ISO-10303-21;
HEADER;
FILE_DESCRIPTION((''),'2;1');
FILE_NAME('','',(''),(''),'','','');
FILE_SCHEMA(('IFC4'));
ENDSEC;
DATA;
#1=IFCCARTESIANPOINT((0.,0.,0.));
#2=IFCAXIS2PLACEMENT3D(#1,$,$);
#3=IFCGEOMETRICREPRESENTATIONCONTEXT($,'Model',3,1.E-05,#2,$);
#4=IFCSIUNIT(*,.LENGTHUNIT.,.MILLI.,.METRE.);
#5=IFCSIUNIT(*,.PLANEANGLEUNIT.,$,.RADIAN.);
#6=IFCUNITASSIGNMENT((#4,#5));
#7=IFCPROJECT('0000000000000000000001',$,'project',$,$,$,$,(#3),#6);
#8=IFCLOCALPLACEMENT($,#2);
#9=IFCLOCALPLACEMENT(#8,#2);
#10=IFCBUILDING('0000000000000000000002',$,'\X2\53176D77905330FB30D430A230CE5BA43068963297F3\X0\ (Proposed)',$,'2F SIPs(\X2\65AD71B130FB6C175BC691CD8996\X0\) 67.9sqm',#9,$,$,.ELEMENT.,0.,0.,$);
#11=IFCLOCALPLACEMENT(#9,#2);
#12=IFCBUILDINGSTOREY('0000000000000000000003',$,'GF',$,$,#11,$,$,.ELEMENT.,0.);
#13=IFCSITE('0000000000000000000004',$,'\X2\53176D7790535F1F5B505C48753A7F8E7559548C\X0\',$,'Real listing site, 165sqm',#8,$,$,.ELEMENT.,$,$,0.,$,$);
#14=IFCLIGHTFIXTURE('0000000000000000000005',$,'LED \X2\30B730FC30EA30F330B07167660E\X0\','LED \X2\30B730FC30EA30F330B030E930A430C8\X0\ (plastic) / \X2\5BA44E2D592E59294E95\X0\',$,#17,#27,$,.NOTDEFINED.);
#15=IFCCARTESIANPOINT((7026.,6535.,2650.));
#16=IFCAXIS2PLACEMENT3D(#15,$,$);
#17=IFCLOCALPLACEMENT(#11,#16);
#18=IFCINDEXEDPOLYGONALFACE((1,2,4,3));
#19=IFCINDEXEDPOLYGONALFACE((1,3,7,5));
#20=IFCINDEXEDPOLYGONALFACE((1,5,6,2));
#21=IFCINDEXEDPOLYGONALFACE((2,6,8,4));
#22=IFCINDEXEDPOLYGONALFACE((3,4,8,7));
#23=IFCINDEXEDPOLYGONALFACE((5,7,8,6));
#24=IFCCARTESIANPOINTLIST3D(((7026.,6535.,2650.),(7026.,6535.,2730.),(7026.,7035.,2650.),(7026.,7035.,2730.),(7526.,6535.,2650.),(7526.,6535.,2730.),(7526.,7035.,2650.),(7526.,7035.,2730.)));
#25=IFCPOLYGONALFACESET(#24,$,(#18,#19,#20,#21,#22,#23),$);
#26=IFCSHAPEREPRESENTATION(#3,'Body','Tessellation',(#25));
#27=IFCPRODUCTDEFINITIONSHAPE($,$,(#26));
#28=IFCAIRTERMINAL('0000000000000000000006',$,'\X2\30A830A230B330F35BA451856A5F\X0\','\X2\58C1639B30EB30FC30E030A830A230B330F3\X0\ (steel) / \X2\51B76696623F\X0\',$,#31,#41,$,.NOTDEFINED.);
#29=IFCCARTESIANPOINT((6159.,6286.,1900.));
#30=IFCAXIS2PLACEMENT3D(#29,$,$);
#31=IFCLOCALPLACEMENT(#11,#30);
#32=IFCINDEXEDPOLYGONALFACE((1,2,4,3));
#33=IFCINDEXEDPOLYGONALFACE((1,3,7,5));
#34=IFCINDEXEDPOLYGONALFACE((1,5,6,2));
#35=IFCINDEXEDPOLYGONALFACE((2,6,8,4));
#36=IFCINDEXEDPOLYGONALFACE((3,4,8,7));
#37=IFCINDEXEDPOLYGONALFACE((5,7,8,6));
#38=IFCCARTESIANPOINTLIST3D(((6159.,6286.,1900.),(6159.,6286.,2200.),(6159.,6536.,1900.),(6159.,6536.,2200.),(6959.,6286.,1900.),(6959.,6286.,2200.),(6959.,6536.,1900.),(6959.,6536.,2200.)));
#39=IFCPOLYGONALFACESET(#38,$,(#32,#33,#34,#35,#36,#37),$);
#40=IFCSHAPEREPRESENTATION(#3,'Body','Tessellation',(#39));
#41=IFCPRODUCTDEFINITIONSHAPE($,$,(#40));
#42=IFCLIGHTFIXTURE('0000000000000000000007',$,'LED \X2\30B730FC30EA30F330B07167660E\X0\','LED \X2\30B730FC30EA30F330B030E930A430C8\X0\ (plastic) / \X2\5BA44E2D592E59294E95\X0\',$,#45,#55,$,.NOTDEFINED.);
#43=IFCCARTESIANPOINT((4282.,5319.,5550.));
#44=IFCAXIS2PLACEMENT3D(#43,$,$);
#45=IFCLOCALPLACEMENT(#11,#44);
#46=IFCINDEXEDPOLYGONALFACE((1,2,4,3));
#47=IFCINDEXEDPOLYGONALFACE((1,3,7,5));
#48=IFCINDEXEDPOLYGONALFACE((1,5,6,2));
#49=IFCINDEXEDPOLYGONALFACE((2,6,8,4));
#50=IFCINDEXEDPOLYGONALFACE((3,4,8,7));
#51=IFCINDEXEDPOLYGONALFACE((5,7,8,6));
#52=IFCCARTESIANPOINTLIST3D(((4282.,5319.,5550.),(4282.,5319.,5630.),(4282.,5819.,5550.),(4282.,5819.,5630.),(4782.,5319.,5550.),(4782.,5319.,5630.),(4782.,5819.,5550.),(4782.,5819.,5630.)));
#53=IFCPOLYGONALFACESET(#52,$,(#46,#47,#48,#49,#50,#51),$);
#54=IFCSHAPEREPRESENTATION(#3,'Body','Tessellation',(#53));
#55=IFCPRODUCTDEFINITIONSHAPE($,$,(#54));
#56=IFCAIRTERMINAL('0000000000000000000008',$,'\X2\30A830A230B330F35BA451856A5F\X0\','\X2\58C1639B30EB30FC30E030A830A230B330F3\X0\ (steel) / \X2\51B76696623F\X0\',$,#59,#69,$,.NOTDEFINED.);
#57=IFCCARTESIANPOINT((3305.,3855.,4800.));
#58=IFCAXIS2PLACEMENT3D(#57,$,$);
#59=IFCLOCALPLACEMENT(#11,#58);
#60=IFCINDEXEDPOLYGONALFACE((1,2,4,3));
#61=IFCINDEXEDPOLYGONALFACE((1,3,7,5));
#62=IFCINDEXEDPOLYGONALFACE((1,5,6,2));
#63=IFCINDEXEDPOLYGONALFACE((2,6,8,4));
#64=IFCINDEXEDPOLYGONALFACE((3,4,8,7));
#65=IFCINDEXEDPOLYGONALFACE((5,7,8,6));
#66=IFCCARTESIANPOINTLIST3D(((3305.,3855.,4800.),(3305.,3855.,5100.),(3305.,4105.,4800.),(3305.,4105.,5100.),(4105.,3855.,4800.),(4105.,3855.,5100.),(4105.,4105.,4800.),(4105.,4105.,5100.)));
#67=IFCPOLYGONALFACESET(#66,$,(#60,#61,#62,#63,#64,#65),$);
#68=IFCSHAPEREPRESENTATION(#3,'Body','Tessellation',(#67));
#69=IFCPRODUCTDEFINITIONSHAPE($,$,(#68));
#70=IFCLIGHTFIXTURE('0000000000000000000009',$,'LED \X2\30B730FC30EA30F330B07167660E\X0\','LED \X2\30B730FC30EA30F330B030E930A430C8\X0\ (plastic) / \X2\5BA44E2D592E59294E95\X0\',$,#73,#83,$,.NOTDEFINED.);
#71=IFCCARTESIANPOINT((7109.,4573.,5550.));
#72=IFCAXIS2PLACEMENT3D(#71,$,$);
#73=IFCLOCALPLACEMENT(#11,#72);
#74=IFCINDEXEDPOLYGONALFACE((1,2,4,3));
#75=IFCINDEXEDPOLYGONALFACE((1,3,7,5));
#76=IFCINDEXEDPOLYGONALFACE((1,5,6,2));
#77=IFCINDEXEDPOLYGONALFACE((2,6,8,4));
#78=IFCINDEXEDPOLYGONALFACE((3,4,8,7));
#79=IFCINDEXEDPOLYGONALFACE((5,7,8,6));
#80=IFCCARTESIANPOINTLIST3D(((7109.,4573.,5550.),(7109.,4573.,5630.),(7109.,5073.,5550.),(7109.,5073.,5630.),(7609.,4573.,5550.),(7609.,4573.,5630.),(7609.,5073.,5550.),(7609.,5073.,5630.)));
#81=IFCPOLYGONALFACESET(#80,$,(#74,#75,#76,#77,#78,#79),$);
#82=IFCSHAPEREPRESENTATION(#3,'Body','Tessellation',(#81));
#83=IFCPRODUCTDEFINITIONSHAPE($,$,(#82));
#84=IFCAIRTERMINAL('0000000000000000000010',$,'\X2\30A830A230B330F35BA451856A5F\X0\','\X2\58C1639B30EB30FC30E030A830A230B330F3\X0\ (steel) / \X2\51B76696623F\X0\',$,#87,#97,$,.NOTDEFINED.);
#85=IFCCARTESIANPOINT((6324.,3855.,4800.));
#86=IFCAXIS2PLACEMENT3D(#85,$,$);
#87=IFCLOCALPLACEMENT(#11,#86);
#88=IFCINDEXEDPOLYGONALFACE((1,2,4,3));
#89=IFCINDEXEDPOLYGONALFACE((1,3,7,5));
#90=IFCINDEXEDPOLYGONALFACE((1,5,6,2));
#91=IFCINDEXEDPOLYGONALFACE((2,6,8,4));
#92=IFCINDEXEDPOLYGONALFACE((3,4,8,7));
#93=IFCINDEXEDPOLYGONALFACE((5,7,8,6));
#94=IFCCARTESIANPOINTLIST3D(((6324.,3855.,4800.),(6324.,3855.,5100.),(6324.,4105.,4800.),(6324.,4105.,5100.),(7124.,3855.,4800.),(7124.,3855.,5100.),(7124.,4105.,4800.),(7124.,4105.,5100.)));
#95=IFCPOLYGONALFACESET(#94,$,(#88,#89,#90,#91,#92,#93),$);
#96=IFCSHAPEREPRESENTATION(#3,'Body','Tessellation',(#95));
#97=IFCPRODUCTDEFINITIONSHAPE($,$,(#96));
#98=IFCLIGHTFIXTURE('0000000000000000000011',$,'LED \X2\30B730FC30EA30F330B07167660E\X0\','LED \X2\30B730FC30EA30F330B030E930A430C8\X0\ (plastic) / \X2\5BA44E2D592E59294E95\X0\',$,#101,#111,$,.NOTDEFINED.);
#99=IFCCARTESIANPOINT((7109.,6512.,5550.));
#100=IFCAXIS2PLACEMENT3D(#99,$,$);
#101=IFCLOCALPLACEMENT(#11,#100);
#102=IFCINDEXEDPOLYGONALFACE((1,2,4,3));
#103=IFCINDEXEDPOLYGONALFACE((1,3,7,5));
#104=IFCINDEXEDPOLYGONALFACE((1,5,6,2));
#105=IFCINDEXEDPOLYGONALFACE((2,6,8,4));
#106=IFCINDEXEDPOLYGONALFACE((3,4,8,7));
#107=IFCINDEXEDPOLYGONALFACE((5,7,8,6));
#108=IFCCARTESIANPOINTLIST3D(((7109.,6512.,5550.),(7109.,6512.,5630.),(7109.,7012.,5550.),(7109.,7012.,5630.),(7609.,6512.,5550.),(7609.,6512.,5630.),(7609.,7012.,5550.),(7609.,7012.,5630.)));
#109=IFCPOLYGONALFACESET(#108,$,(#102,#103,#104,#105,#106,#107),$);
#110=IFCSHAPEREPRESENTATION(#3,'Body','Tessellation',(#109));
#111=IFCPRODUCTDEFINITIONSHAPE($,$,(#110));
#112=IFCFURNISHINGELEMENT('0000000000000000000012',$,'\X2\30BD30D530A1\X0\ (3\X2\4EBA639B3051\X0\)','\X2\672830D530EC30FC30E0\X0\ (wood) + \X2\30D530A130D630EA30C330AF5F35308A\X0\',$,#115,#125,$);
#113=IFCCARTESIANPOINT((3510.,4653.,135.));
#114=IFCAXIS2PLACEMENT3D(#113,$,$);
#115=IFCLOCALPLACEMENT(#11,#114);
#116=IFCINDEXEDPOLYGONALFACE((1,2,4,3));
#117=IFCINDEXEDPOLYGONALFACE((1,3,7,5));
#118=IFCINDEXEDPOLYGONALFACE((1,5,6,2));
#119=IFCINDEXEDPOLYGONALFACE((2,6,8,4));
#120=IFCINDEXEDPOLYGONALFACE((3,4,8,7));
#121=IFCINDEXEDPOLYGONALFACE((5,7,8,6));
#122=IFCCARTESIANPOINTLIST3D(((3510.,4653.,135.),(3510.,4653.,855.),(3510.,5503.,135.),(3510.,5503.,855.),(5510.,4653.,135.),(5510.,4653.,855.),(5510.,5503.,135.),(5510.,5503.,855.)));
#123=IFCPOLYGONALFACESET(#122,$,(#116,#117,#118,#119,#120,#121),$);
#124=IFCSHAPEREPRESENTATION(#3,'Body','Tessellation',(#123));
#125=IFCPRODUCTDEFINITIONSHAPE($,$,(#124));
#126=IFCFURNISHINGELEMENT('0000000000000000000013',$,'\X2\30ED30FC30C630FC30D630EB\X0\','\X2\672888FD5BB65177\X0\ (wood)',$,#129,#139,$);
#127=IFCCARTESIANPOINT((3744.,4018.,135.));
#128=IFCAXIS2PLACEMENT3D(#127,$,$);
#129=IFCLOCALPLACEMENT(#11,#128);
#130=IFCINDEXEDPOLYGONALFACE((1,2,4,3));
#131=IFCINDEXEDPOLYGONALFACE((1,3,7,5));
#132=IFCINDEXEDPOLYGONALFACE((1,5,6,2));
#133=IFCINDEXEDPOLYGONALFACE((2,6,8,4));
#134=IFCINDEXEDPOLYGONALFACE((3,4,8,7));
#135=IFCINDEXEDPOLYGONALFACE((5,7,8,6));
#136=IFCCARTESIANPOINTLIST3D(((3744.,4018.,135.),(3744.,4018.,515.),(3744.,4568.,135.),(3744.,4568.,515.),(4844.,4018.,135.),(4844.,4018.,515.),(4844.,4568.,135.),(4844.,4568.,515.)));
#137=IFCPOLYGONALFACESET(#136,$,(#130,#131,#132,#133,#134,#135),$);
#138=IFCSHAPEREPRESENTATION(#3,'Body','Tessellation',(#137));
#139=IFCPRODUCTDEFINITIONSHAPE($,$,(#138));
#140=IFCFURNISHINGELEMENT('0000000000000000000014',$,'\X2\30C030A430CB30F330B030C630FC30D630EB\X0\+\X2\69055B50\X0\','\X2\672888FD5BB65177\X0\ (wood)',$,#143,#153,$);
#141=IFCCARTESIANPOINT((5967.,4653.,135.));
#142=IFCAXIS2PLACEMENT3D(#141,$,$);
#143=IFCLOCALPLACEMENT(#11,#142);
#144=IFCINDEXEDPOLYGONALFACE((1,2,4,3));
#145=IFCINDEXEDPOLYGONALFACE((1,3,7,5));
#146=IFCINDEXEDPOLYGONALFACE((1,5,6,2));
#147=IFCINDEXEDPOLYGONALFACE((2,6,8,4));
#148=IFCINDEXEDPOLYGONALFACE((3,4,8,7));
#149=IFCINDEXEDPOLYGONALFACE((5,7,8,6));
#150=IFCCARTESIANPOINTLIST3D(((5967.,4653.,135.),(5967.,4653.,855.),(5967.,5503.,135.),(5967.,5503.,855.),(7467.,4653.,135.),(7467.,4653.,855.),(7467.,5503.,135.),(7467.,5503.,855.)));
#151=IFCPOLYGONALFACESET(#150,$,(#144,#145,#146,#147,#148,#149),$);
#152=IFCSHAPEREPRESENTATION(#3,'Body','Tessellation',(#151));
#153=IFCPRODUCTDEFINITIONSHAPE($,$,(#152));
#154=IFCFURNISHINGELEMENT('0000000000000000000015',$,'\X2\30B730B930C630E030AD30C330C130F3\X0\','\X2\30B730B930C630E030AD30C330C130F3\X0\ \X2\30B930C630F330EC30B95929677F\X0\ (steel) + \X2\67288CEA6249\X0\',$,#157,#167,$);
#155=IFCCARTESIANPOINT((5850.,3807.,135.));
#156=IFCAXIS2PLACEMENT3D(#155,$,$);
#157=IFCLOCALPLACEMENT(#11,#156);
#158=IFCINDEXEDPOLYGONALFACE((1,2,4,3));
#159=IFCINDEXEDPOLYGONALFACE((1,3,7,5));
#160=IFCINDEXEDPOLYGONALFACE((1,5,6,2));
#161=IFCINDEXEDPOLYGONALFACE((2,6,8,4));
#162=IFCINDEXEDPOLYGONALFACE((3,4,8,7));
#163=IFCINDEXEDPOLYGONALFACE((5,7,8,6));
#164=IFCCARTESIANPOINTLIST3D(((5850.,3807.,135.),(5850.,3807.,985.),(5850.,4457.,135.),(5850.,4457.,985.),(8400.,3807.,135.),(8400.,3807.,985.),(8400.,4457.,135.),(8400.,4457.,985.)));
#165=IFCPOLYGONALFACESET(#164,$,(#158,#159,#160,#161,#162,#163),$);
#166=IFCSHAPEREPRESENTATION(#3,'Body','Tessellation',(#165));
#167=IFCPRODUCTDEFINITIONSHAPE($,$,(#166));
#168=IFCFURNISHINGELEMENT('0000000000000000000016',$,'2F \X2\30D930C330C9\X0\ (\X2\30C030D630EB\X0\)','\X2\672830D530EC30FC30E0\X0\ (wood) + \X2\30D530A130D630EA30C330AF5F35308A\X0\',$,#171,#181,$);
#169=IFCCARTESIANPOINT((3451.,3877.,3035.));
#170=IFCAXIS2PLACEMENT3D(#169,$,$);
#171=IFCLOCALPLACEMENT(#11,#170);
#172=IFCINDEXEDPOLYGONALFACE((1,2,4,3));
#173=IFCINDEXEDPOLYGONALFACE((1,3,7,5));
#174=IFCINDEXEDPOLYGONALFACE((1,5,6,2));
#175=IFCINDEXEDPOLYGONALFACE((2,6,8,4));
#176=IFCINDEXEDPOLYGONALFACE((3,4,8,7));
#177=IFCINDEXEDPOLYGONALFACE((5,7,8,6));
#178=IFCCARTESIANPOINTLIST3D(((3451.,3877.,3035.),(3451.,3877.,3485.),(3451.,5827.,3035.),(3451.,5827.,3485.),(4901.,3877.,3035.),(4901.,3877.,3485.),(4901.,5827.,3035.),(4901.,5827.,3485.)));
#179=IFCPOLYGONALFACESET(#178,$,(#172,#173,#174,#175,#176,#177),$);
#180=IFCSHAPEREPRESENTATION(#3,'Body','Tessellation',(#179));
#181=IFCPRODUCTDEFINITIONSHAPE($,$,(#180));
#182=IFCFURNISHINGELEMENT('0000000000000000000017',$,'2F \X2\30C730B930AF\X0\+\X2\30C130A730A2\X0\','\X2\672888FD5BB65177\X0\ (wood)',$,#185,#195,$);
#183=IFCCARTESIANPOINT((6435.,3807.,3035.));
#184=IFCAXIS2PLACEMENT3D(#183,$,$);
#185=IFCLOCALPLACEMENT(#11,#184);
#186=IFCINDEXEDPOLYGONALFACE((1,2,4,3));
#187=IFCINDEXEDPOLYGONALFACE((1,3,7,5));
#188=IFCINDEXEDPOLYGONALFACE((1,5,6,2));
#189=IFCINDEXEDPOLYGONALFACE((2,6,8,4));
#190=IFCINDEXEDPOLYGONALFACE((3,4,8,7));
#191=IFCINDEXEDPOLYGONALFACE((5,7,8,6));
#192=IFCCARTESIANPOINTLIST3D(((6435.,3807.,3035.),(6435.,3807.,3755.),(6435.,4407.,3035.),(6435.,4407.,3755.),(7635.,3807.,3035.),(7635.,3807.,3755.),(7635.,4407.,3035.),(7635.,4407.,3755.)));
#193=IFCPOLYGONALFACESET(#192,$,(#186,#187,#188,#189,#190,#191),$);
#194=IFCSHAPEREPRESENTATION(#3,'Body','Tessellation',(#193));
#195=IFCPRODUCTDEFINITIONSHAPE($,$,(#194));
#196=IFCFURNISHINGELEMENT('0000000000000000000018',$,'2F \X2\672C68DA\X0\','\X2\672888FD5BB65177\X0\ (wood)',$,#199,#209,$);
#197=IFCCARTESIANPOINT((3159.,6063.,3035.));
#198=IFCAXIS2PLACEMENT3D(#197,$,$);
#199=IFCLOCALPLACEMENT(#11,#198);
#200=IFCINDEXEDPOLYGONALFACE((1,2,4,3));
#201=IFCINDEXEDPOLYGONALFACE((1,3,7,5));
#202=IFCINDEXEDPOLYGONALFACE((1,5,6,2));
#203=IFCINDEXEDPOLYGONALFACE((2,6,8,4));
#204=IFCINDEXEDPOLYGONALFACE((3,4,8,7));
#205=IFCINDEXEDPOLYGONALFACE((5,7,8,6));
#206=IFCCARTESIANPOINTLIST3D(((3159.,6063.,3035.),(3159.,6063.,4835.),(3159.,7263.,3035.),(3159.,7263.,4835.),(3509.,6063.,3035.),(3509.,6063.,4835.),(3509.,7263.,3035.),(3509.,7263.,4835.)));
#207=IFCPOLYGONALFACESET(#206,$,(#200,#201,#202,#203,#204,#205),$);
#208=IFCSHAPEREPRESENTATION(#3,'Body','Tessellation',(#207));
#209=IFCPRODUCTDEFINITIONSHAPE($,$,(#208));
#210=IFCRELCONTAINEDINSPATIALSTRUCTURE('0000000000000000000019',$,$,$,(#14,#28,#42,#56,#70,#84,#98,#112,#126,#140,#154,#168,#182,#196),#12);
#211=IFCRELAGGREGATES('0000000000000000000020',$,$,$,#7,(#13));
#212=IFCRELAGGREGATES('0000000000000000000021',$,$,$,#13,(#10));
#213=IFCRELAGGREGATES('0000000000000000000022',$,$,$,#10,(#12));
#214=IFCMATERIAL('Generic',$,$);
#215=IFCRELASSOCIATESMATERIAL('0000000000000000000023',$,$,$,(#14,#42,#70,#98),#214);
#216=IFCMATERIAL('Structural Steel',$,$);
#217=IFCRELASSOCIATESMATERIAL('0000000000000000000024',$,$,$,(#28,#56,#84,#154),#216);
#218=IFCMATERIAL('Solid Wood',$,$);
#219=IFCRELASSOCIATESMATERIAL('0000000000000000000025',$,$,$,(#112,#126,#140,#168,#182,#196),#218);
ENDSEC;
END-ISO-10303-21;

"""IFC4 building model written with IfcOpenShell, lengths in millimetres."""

from ifc_helpers import new_model, si_unit, frame, frame_2d, origin, place, context, project, spatial, rectangle, extrude, material, element, save


model = new_model("IFC4")

# Units and contexts
model_context = context("Model", 3, precision=1e-05, world=origin())
ifc_project = project(units=[si_unit("LENGTHUNIT", "METRE", prefix="MILLI"), si_unit("PLANEANGLEUNIT", "RADIAN")], contexts=[model_context])

# Site, building, storey
site_placement = place(None, origin())
site = spatial("IfcSite", under=ifc_project, at=site_placement, Name="北海道弟子屈町美留和", ObjectType="Real listing site, 165sqm", CompositionType="ELEMENT", RefElevation=0.0)
building_placement = place(site_placement, origin())
building = spatial("IfcBuilding", under=site, at=building_placement, Name="北海道・ピアノ室と防音 (Proposed)", ObjectType="2F SIPs(断熱・気密重視) 67.9sqm", CompositionType="ELEMENT", ElevationOfRefHeight=0.0, ElevationOfTerrain=0.0)
storey_placement = place(building_placement, origin())
storey = spatial("IfcBuildingStorey", under=building, at=storey_placement, Name="GF", CompositionType="ELEMENT", Elevation=0.0)

# Shared definitions
ifc_material_1 = material(Name="Solid Wood")

# Shared definitions
ifc_material_2 = material(Name="Structural Steel")

# Shared definitions
ifc_material_3 = material(Name="Generic")

# Light fixture
light_fixture_1_placement = place(storey_placement, frame((7026.0, 6535.0, 2650.0)))
element("IfcLightFixture", 1, at=light_fixture_1_placement, inside=storey, material=ifc_material_3, Name="LED シーリング照明", Description="LED シーリングライト (plastic) / 室中央天井", PredefinedType="NOTDEFINED", context=model_context, shape_type="SweptSolid", body=[
    extrude(rectangle(XDim=500.0, YDim=500.0, at=frame_2d((250.0, 250.0))), frame((7026.0, 6535.0, 2650.0)), (0.0, 0.0, 1.0), 80.0),
])

# Air terminal
air_terminal_1_placement = place(storey_placement, frame((6159.0, 6286.0, 1900.0)))
element("IfcAirTerminal", 2, at=air_terminal_1_placement, inside=storey, material=ifc_material_2, Name="エアコン室内機", Description="壁掛ルームエアコン (steel) / 冷暖房", PredefinedType="NOTDEFINED", context=model_context, shape_type="SweptSolid", body=[
    extrude(rectangle(XDim=800.0, YDim=250.0, at=frame_2d((400.0, 125.0))), frame((6159.0, 6286.0, 1900.0)), (0.0, 0.0, 1.0), 300.0),
])

# Light fixture
light_fixture_2_placement = place(storey_placement, frame((4282.0, 5319.0, 5550.0)))
element("IfcLightFixture", 3, at=light_fixture_2_placement, inside=storey, material=ifc_material_3, Name="LED シーリング照明", Description="LED シーリングライト (plastic) / 室中央天井", PredefinedType="NOTDEFINED", context=model_context, shape_type="SweptSolid", body=[
    extrude(rectangle(XDim=500.0, YDim=500.0, at=frame_2d((250.0, 250.0))), frame((4282.0, 5319.0, 5550.0)), (0.0, 0.0, 1.0), 80.0),
])

# Air terminal
air_terminal_2_placement = place(storey_placement, frame((3305.0, 3855.0, 4800.0)))
element("IfcAirTerminal", 4, at=air_terminal_2_placement, inside=storey, material=ifc_material_2, Name="エアコン室内機", Description="壁掛ルームエアコン (steel) / 冷暖房", PredefinedType="NOTDEFINED", context=model_context, shape_type="SweptSolid", body=[
    extrude(rectangle(XDim=800.0, YDim=250.0, at=frame_2d((400.0, 125.0))), frame((3305.0, 3855.0, 4800.0)), (0.0, 0.0, 1.0), 300.0),
])

# Light fixture
light_fixture_3_placement = place(storey_placement, frame((7109.0, 4573.0, 5550.0)))
element("IfcLightFixture", 5, at=light_fixture_3_placement, inside=storey, material=ifc_material_3, Name="LED シーリング照明", Description="LED シーリングライト (plastic) / 室中央天井", PredefinedType="NOTDEFINED", context=model_context, shape_type="SweptSolid", body=[
    extrude(rectangle(XDim=500.0, YDim=500.0, at=frame_2d((250.0, 250.0))), frame((7109.0, 4573.0, 5550.0)), (0.0, 0.0, 1.0), 80.0),
])

# Air terminal
air_terminal_3_placement = place(storey_placement, frame((6324.0, 3855.0, 4800.0)))
element("IfcAirTerminal", 6, at=air_terminal_3_placement, inside=storey, material=ifc_material_2, Name="エアコン室内機", Description="壁掛ルームエアコン (steel) / 冷暖房", PredefinedType="NOTDEFINED", context=model_context, shape_type="SweptSolid", body=[
    extrude(rectangle(XDim=800.0, YDim=250.0, at=frame_2d((400.0, 125.0))), frame((6324.0, 3855.0, 4800.0)), (0.0, 0.0, 1.0), 300.0),
])

# Light fixture
light_fixture_4_placement = place(storey_placement, frame((7109.0, 6512.0, 5550.0)))
element("IfcLightFixture", 7, at=light_fixture_4_placement, inside=storey, material=ifc_material_3, Name="LED シーリング照明", Description="LED シーリングライト (plastic) / 室中央天井", PredefinedType="NOTDEFINED", context=model_context, shape_type="SweptSolid", body=[
    extrude(rectangle(XDim=500.0, YDim=500.0, at=frame_2d((250.0, 250.0))), frame((7109.0, 6512.0, 5550.0)), (0.0, 0.0, 1.0), 80.0),
])

# Furnishing elements
furnishing_1_placement = place(storey_placement, frame((3510.0, 4653.0, 135.0)))
element("IfcFurnishingElement", 8, at=furnishing_1_placement, inside=storey, material=ifc_material_1, Name="ソファ (3人掛け)", Description="木フレーム (wood) + ファブリック張り", context=model_context, shape_type="SweptSolid", body=[
    extrude(rectangle(XDim=2000.0, YDim=850.0, at=frame_2d((1000.0, 425.0))), frame((3510.0, 4653.0, 135.0)), (0.0, 0.0, 1.0), 720.0),
])
furnishing_2_placement = place(storey_placement, frame((3744.0, 4018.0, 135.0)))
element("IfcFurnishingElement", 9, at=furnishing_2_placement, inside=storey, material=ifc_material_1, Name="ローテーブル", Description="木製家具 (wood)", context=model_context, shape_type="SweptSolid", body=[
    extrude(rectangle(XDim=1100.0, YDim=550.0, at=frame_2d((550.0, 275.0))), frame((3744.0, 4018.0, 135.0)), (0.0, 0.0, 1.0), 380.0),
])
furnishing_3_placement = place(storey_placement, frame((5967.0, 4653.0, 135.0)))
element("IfcFurnishingElement", 10, at=furnishing_3_placement, inside=storey, material=ifc_material_1, Name="ダイニングテーブル+椅子", Description="木製家具 (wood)", context=model_context, shape_type="SweptSolid", body=[
    extrude(rectangle(XDim=1500.0, YDim=850.0, at=frame_2d((750.0, 425.0))), frame((5967.0, 4653.0, 135.0)), (0.0, 0.0, 1.0), 720.0),
])
furnishing_4_placement = place(storey_placement, frame((5850.0, 3807.0, 135.0)))
element("IfcFurnishingElement", 11, at=furnishing_4_placement, inside=storey, material=ifc_material_2, Name="システムキッチン", Description="システムキッチン ステンレス天板 (steel) + 木質扉", context=model_context, shape_type="SweptSolid", body=[
    extrude(rectangle(XDim=2550.0, YDim=650.0, at=frame_2d((1275.0, 325.0))), frame((5850.0, 3807.0, 135.0)), (0.0, 0.0, 1.0), 850.0),
])
furnishing_5_placement = place(storey_placement, frame((3451.0, 3877.0, 3035.0)))
element("IfcFurnishingElement", 12, at=furnishing_5_placement, inside=storey, material=ifc_material_1, Name="2F ベッド (ダブル)", Description="木フレーム (wood) + ファブリック張り", context=model_context, shape_type="SweptSolid", body=[
    extrude(rectangle(XDim=1450.0, YDim=1950.0, at=frame_2d((725.0, 975.0))), frame((3451.0, 3877.0, 3035.0)), (0.0, 0.0, 1.0), 450.0),
])
furnishing_6_placement = place(storey_placement, frame((6435.0, 3807.0, 3035.0)))
element("IfcFurnishingElement", 13, at=furnishing_6_placement, inside=storey, material=ifc_material_1, Name="2F デスク+チェア", Description="木製家具 (wood)", context=model_context, shape_type="SweptSolid", body=[
    extrude(rectangle(XDim=1200.0, YDim=600.0, at=frame_2d((600.0, 300.0))), frame((6435.0, 3807.0, 3035.0)), (0.0, 0.0, 1.0), 720.0),
])
furnishing_7_placement = place(storey_placement, frame((3159.0, 6063.0, 3035.0)))
element("IfcFurnishingElement", 14, at=furnishing_7_placement, inside=storey, material=ifc_material_1, Name="2F 本棚", Description="木製家具 (wood)", context=model_context, shape_type="SweptSolid", body=[
    extrude(rectangle(XDim=350.0, YDim=1200.0, at=frame_2d((175.0, 600.0))), frame((3159.0, 6063.0, 3035.0)), (0.0, 0.0, 1.0), 1800.0),
])

save(model, "model.ifc")
